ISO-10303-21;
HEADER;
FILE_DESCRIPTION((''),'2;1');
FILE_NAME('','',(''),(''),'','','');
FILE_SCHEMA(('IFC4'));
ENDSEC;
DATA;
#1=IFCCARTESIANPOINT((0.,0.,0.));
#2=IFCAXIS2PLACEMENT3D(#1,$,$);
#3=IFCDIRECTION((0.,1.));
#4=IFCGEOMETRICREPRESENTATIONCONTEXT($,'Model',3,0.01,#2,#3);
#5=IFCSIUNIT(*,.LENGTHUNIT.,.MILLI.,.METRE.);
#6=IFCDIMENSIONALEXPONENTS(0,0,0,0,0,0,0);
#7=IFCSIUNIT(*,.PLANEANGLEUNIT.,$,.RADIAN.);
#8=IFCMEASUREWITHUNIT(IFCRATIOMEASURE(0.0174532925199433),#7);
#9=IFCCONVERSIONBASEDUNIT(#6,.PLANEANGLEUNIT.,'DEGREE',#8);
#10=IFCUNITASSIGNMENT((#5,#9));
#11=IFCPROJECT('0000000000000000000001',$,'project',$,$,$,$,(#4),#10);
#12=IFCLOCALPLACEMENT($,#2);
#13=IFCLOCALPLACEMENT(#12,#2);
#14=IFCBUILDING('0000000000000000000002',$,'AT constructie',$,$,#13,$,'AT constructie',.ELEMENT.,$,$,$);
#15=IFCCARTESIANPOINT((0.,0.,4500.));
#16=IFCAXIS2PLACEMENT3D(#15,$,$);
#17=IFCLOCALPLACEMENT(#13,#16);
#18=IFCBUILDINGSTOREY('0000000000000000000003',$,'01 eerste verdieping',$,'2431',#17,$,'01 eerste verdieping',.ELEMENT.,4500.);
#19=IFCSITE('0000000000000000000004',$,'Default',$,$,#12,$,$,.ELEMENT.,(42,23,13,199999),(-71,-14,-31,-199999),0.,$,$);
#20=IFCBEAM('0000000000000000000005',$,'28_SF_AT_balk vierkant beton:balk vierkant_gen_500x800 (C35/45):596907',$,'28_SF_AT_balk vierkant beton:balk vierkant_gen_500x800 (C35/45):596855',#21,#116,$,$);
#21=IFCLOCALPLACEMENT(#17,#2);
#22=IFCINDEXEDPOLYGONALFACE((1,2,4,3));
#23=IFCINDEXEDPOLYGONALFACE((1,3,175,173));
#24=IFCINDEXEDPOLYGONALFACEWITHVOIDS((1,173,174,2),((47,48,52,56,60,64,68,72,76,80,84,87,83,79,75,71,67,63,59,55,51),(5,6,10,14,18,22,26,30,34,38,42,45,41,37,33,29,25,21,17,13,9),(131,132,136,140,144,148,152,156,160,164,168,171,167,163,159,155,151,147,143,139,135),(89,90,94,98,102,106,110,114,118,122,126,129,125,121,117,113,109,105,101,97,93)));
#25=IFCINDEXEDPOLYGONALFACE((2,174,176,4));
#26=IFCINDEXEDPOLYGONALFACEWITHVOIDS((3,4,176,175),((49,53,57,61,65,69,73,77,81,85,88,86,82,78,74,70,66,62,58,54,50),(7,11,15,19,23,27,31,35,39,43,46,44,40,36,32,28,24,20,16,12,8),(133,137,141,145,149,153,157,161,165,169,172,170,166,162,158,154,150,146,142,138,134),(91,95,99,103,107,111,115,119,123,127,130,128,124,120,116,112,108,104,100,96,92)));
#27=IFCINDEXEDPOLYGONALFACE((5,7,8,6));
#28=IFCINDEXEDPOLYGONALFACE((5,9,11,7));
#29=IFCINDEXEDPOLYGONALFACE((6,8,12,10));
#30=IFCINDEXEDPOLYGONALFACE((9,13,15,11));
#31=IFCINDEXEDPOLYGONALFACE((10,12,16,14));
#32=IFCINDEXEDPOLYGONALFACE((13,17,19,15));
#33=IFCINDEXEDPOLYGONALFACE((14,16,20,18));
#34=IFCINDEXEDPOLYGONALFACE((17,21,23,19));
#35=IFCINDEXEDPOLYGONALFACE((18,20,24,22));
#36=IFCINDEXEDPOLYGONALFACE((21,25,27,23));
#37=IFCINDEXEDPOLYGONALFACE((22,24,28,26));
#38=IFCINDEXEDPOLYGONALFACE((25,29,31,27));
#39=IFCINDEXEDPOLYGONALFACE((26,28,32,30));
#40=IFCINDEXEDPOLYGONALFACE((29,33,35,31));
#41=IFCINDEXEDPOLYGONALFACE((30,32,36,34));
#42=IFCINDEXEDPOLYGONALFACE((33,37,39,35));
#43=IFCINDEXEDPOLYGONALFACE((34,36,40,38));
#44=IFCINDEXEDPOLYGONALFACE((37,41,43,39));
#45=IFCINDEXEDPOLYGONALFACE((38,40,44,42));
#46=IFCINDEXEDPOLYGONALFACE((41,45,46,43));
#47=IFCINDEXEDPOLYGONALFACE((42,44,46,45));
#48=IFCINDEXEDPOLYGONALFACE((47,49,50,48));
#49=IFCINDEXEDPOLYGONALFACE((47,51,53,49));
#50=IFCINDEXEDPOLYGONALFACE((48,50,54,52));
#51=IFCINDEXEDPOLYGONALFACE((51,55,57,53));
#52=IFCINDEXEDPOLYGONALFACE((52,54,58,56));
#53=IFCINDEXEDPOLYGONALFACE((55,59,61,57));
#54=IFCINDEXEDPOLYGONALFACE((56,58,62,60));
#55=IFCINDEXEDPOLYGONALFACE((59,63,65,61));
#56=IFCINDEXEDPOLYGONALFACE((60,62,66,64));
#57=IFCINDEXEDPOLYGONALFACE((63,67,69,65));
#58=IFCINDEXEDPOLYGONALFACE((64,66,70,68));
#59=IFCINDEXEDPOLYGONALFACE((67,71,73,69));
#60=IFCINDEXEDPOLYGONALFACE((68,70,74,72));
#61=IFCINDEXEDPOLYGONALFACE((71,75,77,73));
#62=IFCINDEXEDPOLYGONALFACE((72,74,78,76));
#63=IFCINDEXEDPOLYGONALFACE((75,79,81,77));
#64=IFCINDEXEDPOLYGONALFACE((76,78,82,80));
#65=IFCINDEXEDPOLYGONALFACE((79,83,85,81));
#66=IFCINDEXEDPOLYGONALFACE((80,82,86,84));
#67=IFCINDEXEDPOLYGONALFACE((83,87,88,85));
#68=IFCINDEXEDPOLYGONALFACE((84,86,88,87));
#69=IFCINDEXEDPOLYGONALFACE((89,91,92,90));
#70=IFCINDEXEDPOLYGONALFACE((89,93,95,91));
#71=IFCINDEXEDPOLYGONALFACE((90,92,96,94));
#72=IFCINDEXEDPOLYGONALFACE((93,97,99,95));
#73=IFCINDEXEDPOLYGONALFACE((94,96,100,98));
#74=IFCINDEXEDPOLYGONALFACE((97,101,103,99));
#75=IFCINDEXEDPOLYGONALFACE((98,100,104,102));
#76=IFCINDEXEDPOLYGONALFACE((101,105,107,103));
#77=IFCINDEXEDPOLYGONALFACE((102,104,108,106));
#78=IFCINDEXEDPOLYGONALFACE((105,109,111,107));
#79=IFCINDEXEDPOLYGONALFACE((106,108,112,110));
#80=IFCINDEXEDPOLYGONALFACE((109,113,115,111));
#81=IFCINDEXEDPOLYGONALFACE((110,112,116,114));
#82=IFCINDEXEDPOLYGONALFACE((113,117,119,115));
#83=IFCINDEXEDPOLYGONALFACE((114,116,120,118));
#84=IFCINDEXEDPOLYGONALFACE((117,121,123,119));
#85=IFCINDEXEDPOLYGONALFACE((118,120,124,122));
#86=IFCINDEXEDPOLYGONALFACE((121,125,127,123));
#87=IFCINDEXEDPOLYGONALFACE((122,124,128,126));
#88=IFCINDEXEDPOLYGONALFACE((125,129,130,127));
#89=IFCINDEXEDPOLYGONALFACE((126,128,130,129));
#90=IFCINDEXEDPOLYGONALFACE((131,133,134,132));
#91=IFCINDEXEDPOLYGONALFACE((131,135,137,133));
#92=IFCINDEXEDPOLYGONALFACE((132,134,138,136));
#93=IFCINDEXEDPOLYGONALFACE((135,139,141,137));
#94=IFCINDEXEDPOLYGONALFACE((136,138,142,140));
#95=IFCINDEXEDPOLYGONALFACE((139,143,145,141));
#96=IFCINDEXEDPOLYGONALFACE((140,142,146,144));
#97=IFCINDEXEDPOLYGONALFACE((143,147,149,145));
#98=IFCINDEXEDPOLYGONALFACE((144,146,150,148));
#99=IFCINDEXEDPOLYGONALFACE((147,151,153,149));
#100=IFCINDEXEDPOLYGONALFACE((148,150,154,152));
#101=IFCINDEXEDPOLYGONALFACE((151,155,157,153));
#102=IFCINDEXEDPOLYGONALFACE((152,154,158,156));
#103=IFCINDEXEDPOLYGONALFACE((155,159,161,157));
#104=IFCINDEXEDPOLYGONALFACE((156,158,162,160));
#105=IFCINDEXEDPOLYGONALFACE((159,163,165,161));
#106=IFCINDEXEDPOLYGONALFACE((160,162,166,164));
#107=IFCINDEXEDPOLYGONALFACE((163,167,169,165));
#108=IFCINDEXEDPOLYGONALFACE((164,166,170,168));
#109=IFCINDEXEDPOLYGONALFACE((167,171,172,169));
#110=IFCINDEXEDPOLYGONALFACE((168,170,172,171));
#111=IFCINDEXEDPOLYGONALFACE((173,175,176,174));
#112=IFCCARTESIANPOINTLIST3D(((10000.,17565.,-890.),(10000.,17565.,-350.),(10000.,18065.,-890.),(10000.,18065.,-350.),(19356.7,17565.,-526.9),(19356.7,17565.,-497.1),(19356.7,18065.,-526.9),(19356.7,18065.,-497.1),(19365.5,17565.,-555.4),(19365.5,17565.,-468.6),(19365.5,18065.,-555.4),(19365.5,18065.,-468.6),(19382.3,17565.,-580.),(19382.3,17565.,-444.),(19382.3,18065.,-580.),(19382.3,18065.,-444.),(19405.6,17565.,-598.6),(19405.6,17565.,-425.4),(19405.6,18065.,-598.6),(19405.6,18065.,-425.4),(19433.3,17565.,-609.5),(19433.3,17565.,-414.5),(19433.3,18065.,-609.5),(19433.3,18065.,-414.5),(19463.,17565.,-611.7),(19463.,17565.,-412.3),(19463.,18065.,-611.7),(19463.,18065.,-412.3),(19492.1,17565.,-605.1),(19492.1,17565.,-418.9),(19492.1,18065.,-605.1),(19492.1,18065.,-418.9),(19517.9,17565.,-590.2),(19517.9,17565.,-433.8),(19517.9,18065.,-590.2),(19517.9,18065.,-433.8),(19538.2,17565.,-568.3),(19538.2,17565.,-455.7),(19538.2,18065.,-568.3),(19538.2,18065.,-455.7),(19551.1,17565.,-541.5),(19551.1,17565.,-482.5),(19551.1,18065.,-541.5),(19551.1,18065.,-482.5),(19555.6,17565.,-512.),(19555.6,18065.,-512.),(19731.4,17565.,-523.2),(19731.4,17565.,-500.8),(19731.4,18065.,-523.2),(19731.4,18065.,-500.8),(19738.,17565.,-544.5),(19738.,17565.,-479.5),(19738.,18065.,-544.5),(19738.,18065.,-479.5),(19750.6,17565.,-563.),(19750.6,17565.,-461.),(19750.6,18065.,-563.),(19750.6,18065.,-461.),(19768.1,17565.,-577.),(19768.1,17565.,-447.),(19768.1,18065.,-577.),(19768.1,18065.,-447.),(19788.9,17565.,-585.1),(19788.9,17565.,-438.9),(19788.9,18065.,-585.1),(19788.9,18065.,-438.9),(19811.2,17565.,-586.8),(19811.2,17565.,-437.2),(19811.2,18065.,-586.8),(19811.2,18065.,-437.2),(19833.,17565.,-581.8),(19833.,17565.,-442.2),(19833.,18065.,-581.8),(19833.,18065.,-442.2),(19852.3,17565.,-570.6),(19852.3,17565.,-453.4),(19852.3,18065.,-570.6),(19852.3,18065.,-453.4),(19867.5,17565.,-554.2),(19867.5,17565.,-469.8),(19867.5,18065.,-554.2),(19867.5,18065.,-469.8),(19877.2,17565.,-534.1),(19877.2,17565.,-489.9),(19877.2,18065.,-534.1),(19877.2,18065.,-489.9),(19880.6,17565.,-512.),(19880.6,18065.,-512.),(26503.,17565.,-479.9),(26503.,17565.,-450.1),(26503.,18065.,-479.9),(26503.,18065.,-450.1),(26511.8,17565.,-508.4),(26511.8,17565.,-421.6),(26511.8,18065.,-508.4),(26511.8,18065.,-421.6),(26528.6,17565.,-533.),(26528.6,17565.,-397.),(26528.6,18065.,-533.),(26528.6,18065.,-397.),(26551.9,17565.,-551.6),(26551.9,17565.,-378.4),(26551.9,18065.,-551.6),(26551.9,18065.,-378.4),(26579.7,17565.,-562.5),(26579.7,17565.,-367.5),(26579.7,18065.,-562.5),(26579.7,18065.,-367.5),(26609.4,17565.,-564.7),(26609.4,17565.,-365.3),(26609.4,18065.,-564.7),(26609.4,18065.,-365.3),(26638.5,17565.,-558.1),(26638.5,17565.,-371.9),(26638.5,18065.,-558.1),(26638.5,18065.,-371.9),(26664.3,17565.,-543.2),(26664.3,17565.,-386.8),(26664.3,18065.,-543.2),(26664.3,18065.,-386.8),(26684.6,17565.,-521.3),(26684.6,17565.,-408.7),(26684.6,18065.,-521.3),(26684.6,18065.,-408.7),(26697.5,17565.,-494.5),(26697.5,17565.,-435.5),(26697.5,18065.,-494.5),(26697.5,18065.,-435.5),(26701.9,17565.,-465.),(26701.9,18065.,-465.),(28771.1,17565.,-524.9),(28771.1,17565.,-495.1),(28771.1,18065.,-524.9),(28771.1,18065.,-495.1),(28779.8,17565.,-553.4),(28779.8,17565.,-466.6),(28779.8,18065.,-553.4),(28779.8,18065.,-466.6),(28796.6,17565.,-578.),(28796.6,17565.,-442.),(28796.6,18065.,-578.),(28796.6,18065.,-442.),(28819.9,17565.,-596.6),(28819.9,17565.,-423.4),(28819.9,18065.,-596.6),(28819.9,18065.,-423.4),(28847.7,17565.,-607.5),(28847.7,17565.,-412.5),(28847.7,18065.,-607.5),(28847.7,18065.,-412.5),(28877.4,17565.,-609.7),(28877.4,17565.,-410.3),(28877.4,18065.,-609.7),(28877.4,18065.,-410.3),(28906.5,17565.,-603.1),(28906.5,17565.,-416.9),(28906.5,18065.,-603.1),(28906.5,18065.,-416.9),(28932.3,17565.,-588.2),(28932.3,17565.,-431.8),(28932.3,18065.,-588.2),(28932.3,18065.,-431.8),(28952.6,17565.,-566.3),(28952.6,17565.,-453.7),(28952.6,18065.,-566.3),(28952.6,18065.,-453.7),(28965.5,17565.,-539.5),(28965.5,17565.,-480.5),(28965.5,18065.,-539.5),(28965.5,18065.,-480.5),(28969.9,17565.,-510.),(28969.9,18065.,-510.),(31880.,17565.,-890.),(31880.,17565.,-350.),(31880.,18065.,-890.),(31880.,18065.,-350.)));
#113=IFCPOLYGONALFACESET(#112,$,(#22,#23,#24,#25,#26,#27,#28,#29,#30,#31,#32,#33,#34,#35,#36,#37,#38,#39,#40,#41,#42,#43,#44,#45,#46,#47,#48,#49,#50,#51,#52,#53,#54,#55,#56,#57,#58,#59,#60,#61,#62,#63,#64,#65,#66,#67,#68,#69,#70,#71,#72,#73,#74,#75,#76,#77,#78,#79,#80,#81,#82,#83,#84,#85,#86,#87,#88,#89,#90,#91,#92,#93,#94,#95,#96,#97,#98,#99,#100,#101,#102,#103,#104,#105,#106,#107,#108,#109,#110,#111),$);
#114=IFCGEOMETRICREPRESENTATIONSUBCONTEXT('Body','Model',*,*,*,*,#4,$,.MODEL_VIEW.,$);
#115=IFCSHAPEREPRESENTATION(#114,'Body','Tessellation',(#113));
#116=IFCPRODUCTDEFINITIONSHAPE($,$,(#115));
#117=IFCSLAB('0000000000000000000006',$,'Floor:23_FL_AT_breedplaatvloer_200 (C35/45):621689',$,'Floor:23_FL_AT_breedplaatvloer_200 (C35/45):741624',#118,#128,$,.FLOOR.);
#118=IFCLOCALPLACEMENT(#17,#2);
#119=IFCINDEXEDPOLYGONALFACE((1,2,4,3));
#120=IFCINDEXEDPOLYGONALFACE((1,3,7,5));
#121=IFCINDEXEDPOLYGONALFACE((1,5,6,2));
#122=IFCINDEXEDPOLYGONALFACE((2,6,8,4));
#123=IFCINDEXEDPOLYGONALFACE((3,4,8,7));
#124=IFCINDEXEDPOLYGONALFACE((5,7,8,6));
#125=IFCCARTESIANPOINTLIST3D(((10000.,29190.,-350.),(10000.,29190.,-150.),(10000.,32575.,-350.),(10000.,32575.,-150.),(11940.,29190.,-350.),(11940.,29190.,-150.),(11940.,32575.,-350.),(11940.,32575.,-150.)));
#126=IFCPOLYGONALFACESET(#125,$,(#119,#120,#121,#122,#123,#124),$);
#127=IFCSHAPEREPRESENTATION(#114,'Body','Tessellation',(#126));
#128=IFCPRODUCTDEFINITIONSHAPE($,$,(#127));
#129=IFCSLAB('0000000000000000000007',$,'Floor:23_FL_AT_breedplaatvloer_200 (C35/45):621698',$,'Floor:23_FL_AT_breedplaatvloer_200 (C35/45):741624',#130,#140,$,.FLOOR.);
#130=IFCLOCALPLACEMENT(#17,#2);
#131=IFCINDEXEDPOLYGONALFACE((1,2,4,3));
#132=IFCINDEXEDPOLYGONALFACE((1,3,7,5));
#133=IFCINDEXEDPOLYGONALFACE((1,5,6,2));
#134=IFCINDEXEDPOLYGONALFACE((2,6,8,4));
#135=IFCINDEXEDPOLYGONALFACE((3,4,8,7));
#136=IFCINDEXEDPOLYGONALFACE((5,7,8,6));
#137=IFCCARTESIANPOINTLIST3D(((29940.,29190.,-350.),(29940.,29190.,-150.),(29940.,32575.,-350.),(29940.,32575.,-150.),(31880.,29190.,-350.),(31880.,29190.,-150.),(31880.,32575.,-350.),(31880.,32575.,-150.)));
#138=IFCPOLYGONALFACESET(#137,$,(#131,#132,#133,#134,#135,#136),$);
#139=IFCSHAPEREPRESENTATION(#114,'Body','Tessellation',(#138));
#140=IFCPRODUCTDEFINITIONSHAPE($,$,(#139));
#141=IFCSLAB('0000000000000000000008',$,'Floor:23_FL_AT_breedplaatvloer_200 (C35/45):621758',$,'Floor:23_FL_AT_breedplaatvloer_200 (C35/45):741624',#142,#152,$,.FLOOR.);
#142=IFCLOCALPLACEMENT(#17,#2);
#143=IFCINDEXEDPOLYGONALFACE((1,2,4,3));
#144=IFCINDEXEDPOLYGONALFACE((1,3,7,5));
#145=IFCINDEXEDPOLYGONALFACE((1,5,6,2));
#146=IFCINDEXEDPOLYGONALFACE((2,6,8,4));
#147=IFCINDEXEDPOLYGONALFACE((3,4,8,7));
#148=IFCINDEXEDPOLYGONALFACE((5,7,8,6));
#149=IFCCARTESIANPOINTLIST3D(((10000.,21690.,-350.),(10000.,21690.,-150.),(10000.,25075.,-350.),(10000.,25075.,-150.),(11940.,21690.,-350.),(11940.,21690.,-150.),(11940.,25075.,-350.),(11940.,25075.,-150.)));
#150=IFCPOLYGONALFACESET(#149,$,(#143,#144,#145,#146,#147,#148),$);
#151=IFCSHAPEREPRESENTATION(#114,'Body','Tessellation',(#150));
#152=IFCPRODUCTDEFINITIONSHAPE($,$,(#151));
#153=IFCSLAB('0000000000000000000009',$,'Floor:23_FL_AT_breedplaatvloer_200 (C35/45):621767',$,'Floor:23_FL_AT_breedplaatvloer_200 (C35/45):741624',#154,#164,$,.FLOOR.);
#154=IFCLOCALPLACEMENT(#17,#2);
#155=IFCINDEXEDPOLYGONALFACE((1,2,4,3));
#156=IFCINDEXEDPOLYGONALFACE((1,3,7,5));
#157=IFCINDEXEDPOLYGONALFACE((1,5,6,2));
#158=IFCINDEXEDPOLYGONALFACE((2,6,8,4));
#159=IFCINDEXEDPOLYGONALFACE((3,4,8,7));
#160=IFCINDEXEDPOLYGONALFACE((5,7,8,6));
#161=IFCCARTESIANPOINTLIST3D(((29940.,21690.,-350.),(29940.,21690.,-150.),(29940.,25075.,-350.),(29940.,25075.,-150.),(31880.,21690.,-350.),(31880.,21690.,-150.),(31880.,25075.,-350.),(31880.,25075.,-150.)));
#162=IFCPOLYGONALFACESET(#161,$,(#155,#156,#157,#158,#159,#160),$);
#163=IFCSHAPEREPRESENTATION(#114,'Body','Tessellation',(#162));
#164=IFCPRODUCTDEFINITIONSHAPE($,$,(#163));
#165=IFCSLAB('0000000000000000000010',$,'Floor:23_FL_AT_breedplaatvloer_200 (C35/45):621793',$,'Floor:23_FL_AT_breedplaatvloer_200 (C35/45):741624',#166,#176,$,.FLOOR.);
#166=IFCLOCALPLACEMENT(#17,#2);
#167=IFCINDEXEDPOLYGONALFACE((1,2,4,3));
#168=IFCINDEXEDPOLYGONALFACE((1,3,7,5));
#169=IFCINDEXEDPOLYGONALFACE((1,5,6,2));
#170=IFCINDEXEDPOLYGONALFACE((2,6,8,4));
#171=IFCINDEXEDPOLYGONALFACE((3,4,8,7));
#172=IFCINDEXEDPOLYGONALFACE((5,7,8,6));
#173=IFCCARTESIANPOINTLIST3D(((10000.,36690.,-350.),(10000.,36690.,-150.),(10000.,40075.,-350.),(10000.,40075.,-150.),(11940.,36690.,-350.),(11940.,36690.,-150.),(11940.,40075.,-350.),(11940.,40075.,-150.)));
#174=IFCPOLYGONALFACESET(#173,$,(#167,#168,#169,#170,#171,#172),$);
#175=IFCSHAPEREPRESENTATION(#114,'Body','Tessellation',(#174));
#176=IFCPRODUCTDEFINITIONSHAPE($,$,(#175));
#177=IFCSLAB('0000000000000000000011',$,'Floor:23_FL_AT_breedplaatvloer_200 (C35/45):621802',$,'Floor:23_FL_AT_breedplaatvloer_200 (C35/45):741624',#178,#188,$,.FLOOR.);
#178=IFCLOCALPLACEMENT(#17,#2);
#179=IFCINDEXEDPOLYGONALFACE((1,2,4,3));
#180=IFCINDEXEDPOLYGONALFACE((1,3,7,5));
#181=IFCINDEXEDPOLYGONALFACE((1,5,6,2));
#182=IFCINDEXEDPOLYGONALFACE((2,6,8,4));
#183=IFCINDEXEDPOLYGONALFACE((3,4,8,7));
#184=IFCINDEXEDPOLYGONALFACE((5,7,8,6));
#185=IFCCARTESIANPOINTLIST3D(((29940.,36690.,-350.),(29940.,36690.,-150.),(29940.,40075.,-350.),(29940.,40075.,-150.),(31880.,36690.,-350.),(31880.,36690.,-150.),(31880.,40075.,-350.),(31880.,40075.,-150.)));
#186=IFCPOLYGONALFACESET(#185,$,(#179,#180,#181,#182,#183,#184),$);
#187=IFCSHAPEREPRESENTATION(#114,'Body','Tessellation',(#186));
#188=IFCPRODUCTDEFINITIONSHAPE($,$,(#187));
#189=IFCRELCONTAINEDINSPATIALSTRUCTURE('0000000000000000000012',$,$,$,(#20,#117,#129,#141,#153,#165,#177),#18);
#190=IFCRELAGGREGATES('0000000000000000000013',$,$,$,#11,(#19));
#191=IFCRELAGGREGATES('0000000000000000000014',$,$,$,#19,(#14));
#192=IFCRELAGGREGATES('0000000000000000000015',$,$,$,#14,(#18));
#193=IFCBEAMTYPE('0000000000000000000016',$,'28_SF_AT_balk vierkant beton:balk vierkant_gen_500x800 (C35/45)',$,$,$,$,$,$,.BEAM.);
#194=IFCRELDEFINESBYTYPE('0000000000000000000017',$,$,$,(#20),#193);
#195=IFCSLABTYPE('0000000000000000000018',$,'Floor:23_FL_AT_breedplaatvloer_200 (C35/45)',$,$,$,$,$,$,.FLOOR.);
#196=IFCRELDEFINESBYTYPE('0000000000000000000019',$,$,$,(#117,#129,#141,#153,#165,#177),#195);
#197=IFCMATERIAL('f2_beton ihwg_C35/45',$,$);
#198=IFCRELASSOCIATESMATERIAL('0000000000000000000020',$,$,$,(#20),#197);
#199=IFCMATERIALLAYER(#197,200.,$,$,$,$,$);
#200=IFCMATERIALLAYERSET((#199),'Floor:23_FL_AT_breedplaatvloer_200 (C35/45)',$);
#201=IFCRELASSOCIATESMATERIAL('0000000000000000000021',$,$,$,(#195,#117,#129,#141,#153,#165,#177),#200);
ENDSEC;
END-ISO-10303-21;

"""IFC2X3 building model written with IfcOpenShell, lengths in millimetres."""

from ifc_helpers import new_model, entity, si_unit, converted_unit, direction, frame, frame_2d, origin, origin_2d_with_axis, place, context, subcontext, project, spatial, rectangle, circle, extrude, boolean, material, layer, layer_set, layer_usage, type_object, element, save


model = new_model("IFC2X3")

# Units and contexts
model_context = context("Model", 3, precision=0.01, world=origin(), true_north=direction((0.0, 1.0)))
body_context = subcontext(model_context, "Body", "Model", "MODEL_VIEW")
ifc_project = project(units=[si_unit("LENGTHUNIT", "METRE", prefix="MILLI"), converted_unit("PLANEANGLEUNIT", "DEGREE", entity("IfcRatioMeasure", 0.0174532925199433), si_unit("PLANEANGLEUNIT", "RADIAN"), dimensions=[0, 0, 0, 0, 0, 0, 0])], contexts=[model_context])

# Site, building, storey
site_placement = place(None, origin())
site = spatial("IfcSite", under=ifc_project, at=site_placement, Name="Default", CompositionType="ELEMENT", RefLatitude=(42, 23, 13, 199999), RefLongitude=(-71, -14, -31, -199999), RefElevation=0.0)
building_placement = place(site_placement, origin())
building = spatial("IfcBuilding", under=site, at=building_placement, Name="AT constructie", LongName="AT constructie", CompositionType="ELEMENT")
storey_placement = place(building_placement, frame((0.0, 0.0, 4500.0)))
storey = spatial("IfcBuildingStorey", under=building, at=storey_placement, Name="01 eerste verdieping", ObjectType="2431", LongName="01 eerste verdieping", CompositionType="ELEMENT", Elevation=4500.0)

# Beam
ifc_material_1 = material(Name="f2_beton ihwg_C35/45")
beam_type = type_object("IfcBeamType", Name="28_SF_AT_balk vierkant beton:balk vierkant_gen_500x800 (C35/45)", PredefinedType="BEAM")
beam_placement = place(storey_placement, frame((10000.0, 17815.0, -90.0)))
element("IfcBeam", 1, at=beam_placement, inside=storey, type_object=beam_type, material=ifc_material_1, Name="28_SF_AT_balk vierkant beton:balk vierkant_gen_500x800 (C35/45):596907", ObjectType="28_SF_AT_balk vierkant beton:balk vierkant_gen_500x800 (C35/45):596855", context=body_context, shape_type="CSG", body=[
    boolean("DIFFERENCE", boolean("DIFFERENCE", boolean("DIFFERENCE", boolean("DIFFERENCE", extrude(rectangle(XDim=540.0, YDim=500.0, at=frame_2d((0.0, 0.0), x_axis=(0.0, 1.0))), frame((0.0, 0.0, -530.0), z_axis=(1.0, 0.0, 0.0), x_axis=(0.0, 1.0, 0.0)), (0.0, 0.0, 1.0), 21880.0), extrude(circle(Radius=100.0, at=frame_2d((0.0, 0.0), x_axis=(1.0, 0.0))), frame((18869.9, -250.0, -420.0), z_axis=(0.0, 1.0, 0.0), x_axis=(1.0, 0.0, 0.0)), (0.0, 0.0, 1.0), 500.0)), extrude(circle(Radius=100.0, at=frame_2d((0.0, 0.0), x_axis=(1.0, 0.0))), frame((16601.9, 250.0, -375.0), z_axis=(0.0, -1.0, 0.0), x_axis=(1.0, 0.0, 0.0)), (0.0, 0.0, 1.0), 500.0)), extrude(circle(Radius=100.0, at=frame_2d((0.0, 0.0), x_axis=(1.0, 0.0))), frame((9455.6, 250.0, -422.0), z_axis=(0.0, -1.0, 0.0), x_axis=(1.0, 0.0, 0.0)), (0.0, 0.0, 1.0), 500.0)), extrude(circle(Radius=75.0, at=frame_2d((0.0, 0.0), x_axis=(1.0, 0.0))), frame((9805.6, -250.0, -422.0), z_axis=(0.0, 1.0, 0.0), x_axis=(1.0, 0.0, 0.0)), (0.0, 0.0, 1.0), 500.0)),
])

# Slabs
ifc_layer_1 = layer(ifc_material_1, 200.0)
ifc_layer_set_1 = layer_set([ifc_layer_1], Name="Floor:23_FL_AT_breedplaatvloer_200 (C35/45)")
ifc_layer_usage_1 = layer_usage(ifc_layer_set_1, "AXIS3", "POSITIVE", 0.0)
slab_type_1 = type_object("IfcSlabType", Name="Floor:23_FL_AT_breedplaatvloer_200 (C35/45)", PredefinedType="FLOOR", material=ifc_layer_set_1)
slab_1_placement = place(storey_placement, origin())
element("IfcSlab", 2, at=slab_1_placement, inside=storey, type_object=slab_type_1, material=ifc_layer_usage_1, Name="Floor:23_FL_AT_breedplaatvloer_200 (C35/45):621689", ObjectType="Floor:23_FL_AT_breedplaatvloer_200 (C35/45):741624", PredefinedType="FLOOR", context=body_context, shape_type="SweptSolid", body=[
    extrude(rectangle(XDim=3385.0, YDim=1940.0, at=frame_2d((0.0, 0.0), x_axis=(1.0, 0.0))), frame((10970.0, 30882.5, -150.0), z_axis=(0.0, 0.0, -1.0), x_axis=(0.0, 1.0, 0.0)), (0.0, 0.0, 1.0), 200.0),
])
ifc_layer_usage_2 = layer_usage(ifc_layer_set_1, "AXIS3", "POSITIVE", 0.0)
slab_2_placement = place(storey_placement, origin())
element("IfcSlab", 3, at=slab_2_placement, inside=storey, type_object=slab_type_1, material=ifc_layer_usage_2, Name="Floor:23_FL_AT_breedplaatvloer_200 (C35/45):621698", ObjectType="Floor:23_FL_AT_breedplaatvloer_200 (C35/45):741624", PredefinedType="FLOOR", context=body_context, shape_type="SweptSolid", body=[
    extrude(rectangle(XDim=3385.0, YDim=1940.0, at=frame_2d((0.0, 0.0), x_axis=(1.0, 0.0))), frame((30910.0, 30882.5, -150.0), z_axis=(0.0, 0.0, -1.0), x_axis=(0.0, 1.0, 0.0)), (0.0, 0.0, 1.0), 200.0),
])
ifc_layer_usage_3 = layer_usage(ifc_layer_set_1, "AXIS3", "POSITIVE", 0.0)
slab_3_placement = place(storey_placement, origin())
element("IfcSlab", 4, at=slab_3_placement, inside=storey, type_object=slab_type_1, material=ifc_layer_usage_3, Name="Floor:23_FL_AT_breedplaatvloer_200 (C35/45):621758", ObjectType="Floor:23_FL_AT_breedplaatvloer_200 (C35/45):741624", PredefinedType="FLOOR", context=body_context, shape_type="SweptSolid", body=[
    extrude(rectangle(XDim=3385.0, YDim=1940.0, at=frame_2d((0.0, 0.0), x_axis=(1.0, 0.0))), frame((10970.0, 23382.5, -150.0), z_axis=(0.0, 0.0, -1.0), x_axis=(0.0, 1.0, 0.0)), (0.0, 0.0, 1.0), 200.0),
])
ifc_layer_usage_4 = layer_usage(ifc_layer_set_1, "AXIS3", "POSITIVE", 0.0)
slab_4_placement = place(storey_placement, origin())
element("IfcSlab", 5, at=slab_4_placement, inside=storey, type_object=slab_type_1, material=ifc_layer_usage_4, Name="Floor:23_FL_AT_breedplaatvloer_200 (C35/45):621767", ObjectType="Floor:23_FL_AT_breedplaatvloer_200 (C35/45):741624", PredefinedType="FLOOR", context=body_context, shape_type="SweptSolid", body=[
    extrude(rectangle(XDim=3385.0, YDim=1940.0, at=origin_2d_with_axis()), frame((30910.0, 23382.5, -150.0), z_axis=(0.0, 0.0, -1.0), x_axis=(0.0, 1.0, 0.0)), (0.0, 0.0, 1.0), 200.0),
])
ifc_layer_usage_5 = layer_usage(ifc_layer_set_1, "AXIS3", "POSITIVE", 0.0)
slab_5_placement = place(storey_placement, origin())
element("IfcSlab", 6, at=slab_5_placement, inside=storey, type_object=slab_type_1, material=ifc_layer_usage_5, Name="Floor:23_FL_AT_breedplaatvloer_200 (C35/45):621793", ObjectType="Floor:23_FL_AT_breedplaatvloer_200 (C35/45):741624", PredefinedType="FLOOR", context=body_context, shape_type="SweptSolid", body=[
    extrude(rectangle(XDim=3385.0, YDim=1940.0, at=frame_2d((0.0, 0.0), x_axis=(1.0, 0.0))), frame((10970.0, 38382.5, -150.0), z_axis=(0.0, 0.0, -1.0), x_axis=(0.0, 1.0, 0.0)), (0.0, 0.0, 1.0), 200.0),
])
ifc_layer_usage_6 = layer_usage(ifc_layer_set_1, "AXIS3", "POSITIVE", 0.0)
slab_6_placement = place(storey_placement, origin())
element("IfcSlab", 7, at=slab_6_placement, inside=storey, type_object=slab_type_1, material=ifc_layer_usage_6, Name="Floor:23_FL_AT_breedplaatvloer_200 (C35/45):621802", ObjectType="Floor:23_FL_AT_breedplaatvloer_200 (C35/45):741624", PredefinedType="FLOOR", context=body_context, shape_type="SweptSolid", body=[
    extrude(rectangle(XDim=3385.0, YDim=1940.0, at=origin_2d_with_axis()), frame((30910.0, 38382.5, -150.0), z_axis=(0.0, 0.0, -1.0), x_axis=(0.0, 1.0, 0.0)), (0.0, 0.0, 1.0), 200.0),
])

save(model, "model.ifc")
